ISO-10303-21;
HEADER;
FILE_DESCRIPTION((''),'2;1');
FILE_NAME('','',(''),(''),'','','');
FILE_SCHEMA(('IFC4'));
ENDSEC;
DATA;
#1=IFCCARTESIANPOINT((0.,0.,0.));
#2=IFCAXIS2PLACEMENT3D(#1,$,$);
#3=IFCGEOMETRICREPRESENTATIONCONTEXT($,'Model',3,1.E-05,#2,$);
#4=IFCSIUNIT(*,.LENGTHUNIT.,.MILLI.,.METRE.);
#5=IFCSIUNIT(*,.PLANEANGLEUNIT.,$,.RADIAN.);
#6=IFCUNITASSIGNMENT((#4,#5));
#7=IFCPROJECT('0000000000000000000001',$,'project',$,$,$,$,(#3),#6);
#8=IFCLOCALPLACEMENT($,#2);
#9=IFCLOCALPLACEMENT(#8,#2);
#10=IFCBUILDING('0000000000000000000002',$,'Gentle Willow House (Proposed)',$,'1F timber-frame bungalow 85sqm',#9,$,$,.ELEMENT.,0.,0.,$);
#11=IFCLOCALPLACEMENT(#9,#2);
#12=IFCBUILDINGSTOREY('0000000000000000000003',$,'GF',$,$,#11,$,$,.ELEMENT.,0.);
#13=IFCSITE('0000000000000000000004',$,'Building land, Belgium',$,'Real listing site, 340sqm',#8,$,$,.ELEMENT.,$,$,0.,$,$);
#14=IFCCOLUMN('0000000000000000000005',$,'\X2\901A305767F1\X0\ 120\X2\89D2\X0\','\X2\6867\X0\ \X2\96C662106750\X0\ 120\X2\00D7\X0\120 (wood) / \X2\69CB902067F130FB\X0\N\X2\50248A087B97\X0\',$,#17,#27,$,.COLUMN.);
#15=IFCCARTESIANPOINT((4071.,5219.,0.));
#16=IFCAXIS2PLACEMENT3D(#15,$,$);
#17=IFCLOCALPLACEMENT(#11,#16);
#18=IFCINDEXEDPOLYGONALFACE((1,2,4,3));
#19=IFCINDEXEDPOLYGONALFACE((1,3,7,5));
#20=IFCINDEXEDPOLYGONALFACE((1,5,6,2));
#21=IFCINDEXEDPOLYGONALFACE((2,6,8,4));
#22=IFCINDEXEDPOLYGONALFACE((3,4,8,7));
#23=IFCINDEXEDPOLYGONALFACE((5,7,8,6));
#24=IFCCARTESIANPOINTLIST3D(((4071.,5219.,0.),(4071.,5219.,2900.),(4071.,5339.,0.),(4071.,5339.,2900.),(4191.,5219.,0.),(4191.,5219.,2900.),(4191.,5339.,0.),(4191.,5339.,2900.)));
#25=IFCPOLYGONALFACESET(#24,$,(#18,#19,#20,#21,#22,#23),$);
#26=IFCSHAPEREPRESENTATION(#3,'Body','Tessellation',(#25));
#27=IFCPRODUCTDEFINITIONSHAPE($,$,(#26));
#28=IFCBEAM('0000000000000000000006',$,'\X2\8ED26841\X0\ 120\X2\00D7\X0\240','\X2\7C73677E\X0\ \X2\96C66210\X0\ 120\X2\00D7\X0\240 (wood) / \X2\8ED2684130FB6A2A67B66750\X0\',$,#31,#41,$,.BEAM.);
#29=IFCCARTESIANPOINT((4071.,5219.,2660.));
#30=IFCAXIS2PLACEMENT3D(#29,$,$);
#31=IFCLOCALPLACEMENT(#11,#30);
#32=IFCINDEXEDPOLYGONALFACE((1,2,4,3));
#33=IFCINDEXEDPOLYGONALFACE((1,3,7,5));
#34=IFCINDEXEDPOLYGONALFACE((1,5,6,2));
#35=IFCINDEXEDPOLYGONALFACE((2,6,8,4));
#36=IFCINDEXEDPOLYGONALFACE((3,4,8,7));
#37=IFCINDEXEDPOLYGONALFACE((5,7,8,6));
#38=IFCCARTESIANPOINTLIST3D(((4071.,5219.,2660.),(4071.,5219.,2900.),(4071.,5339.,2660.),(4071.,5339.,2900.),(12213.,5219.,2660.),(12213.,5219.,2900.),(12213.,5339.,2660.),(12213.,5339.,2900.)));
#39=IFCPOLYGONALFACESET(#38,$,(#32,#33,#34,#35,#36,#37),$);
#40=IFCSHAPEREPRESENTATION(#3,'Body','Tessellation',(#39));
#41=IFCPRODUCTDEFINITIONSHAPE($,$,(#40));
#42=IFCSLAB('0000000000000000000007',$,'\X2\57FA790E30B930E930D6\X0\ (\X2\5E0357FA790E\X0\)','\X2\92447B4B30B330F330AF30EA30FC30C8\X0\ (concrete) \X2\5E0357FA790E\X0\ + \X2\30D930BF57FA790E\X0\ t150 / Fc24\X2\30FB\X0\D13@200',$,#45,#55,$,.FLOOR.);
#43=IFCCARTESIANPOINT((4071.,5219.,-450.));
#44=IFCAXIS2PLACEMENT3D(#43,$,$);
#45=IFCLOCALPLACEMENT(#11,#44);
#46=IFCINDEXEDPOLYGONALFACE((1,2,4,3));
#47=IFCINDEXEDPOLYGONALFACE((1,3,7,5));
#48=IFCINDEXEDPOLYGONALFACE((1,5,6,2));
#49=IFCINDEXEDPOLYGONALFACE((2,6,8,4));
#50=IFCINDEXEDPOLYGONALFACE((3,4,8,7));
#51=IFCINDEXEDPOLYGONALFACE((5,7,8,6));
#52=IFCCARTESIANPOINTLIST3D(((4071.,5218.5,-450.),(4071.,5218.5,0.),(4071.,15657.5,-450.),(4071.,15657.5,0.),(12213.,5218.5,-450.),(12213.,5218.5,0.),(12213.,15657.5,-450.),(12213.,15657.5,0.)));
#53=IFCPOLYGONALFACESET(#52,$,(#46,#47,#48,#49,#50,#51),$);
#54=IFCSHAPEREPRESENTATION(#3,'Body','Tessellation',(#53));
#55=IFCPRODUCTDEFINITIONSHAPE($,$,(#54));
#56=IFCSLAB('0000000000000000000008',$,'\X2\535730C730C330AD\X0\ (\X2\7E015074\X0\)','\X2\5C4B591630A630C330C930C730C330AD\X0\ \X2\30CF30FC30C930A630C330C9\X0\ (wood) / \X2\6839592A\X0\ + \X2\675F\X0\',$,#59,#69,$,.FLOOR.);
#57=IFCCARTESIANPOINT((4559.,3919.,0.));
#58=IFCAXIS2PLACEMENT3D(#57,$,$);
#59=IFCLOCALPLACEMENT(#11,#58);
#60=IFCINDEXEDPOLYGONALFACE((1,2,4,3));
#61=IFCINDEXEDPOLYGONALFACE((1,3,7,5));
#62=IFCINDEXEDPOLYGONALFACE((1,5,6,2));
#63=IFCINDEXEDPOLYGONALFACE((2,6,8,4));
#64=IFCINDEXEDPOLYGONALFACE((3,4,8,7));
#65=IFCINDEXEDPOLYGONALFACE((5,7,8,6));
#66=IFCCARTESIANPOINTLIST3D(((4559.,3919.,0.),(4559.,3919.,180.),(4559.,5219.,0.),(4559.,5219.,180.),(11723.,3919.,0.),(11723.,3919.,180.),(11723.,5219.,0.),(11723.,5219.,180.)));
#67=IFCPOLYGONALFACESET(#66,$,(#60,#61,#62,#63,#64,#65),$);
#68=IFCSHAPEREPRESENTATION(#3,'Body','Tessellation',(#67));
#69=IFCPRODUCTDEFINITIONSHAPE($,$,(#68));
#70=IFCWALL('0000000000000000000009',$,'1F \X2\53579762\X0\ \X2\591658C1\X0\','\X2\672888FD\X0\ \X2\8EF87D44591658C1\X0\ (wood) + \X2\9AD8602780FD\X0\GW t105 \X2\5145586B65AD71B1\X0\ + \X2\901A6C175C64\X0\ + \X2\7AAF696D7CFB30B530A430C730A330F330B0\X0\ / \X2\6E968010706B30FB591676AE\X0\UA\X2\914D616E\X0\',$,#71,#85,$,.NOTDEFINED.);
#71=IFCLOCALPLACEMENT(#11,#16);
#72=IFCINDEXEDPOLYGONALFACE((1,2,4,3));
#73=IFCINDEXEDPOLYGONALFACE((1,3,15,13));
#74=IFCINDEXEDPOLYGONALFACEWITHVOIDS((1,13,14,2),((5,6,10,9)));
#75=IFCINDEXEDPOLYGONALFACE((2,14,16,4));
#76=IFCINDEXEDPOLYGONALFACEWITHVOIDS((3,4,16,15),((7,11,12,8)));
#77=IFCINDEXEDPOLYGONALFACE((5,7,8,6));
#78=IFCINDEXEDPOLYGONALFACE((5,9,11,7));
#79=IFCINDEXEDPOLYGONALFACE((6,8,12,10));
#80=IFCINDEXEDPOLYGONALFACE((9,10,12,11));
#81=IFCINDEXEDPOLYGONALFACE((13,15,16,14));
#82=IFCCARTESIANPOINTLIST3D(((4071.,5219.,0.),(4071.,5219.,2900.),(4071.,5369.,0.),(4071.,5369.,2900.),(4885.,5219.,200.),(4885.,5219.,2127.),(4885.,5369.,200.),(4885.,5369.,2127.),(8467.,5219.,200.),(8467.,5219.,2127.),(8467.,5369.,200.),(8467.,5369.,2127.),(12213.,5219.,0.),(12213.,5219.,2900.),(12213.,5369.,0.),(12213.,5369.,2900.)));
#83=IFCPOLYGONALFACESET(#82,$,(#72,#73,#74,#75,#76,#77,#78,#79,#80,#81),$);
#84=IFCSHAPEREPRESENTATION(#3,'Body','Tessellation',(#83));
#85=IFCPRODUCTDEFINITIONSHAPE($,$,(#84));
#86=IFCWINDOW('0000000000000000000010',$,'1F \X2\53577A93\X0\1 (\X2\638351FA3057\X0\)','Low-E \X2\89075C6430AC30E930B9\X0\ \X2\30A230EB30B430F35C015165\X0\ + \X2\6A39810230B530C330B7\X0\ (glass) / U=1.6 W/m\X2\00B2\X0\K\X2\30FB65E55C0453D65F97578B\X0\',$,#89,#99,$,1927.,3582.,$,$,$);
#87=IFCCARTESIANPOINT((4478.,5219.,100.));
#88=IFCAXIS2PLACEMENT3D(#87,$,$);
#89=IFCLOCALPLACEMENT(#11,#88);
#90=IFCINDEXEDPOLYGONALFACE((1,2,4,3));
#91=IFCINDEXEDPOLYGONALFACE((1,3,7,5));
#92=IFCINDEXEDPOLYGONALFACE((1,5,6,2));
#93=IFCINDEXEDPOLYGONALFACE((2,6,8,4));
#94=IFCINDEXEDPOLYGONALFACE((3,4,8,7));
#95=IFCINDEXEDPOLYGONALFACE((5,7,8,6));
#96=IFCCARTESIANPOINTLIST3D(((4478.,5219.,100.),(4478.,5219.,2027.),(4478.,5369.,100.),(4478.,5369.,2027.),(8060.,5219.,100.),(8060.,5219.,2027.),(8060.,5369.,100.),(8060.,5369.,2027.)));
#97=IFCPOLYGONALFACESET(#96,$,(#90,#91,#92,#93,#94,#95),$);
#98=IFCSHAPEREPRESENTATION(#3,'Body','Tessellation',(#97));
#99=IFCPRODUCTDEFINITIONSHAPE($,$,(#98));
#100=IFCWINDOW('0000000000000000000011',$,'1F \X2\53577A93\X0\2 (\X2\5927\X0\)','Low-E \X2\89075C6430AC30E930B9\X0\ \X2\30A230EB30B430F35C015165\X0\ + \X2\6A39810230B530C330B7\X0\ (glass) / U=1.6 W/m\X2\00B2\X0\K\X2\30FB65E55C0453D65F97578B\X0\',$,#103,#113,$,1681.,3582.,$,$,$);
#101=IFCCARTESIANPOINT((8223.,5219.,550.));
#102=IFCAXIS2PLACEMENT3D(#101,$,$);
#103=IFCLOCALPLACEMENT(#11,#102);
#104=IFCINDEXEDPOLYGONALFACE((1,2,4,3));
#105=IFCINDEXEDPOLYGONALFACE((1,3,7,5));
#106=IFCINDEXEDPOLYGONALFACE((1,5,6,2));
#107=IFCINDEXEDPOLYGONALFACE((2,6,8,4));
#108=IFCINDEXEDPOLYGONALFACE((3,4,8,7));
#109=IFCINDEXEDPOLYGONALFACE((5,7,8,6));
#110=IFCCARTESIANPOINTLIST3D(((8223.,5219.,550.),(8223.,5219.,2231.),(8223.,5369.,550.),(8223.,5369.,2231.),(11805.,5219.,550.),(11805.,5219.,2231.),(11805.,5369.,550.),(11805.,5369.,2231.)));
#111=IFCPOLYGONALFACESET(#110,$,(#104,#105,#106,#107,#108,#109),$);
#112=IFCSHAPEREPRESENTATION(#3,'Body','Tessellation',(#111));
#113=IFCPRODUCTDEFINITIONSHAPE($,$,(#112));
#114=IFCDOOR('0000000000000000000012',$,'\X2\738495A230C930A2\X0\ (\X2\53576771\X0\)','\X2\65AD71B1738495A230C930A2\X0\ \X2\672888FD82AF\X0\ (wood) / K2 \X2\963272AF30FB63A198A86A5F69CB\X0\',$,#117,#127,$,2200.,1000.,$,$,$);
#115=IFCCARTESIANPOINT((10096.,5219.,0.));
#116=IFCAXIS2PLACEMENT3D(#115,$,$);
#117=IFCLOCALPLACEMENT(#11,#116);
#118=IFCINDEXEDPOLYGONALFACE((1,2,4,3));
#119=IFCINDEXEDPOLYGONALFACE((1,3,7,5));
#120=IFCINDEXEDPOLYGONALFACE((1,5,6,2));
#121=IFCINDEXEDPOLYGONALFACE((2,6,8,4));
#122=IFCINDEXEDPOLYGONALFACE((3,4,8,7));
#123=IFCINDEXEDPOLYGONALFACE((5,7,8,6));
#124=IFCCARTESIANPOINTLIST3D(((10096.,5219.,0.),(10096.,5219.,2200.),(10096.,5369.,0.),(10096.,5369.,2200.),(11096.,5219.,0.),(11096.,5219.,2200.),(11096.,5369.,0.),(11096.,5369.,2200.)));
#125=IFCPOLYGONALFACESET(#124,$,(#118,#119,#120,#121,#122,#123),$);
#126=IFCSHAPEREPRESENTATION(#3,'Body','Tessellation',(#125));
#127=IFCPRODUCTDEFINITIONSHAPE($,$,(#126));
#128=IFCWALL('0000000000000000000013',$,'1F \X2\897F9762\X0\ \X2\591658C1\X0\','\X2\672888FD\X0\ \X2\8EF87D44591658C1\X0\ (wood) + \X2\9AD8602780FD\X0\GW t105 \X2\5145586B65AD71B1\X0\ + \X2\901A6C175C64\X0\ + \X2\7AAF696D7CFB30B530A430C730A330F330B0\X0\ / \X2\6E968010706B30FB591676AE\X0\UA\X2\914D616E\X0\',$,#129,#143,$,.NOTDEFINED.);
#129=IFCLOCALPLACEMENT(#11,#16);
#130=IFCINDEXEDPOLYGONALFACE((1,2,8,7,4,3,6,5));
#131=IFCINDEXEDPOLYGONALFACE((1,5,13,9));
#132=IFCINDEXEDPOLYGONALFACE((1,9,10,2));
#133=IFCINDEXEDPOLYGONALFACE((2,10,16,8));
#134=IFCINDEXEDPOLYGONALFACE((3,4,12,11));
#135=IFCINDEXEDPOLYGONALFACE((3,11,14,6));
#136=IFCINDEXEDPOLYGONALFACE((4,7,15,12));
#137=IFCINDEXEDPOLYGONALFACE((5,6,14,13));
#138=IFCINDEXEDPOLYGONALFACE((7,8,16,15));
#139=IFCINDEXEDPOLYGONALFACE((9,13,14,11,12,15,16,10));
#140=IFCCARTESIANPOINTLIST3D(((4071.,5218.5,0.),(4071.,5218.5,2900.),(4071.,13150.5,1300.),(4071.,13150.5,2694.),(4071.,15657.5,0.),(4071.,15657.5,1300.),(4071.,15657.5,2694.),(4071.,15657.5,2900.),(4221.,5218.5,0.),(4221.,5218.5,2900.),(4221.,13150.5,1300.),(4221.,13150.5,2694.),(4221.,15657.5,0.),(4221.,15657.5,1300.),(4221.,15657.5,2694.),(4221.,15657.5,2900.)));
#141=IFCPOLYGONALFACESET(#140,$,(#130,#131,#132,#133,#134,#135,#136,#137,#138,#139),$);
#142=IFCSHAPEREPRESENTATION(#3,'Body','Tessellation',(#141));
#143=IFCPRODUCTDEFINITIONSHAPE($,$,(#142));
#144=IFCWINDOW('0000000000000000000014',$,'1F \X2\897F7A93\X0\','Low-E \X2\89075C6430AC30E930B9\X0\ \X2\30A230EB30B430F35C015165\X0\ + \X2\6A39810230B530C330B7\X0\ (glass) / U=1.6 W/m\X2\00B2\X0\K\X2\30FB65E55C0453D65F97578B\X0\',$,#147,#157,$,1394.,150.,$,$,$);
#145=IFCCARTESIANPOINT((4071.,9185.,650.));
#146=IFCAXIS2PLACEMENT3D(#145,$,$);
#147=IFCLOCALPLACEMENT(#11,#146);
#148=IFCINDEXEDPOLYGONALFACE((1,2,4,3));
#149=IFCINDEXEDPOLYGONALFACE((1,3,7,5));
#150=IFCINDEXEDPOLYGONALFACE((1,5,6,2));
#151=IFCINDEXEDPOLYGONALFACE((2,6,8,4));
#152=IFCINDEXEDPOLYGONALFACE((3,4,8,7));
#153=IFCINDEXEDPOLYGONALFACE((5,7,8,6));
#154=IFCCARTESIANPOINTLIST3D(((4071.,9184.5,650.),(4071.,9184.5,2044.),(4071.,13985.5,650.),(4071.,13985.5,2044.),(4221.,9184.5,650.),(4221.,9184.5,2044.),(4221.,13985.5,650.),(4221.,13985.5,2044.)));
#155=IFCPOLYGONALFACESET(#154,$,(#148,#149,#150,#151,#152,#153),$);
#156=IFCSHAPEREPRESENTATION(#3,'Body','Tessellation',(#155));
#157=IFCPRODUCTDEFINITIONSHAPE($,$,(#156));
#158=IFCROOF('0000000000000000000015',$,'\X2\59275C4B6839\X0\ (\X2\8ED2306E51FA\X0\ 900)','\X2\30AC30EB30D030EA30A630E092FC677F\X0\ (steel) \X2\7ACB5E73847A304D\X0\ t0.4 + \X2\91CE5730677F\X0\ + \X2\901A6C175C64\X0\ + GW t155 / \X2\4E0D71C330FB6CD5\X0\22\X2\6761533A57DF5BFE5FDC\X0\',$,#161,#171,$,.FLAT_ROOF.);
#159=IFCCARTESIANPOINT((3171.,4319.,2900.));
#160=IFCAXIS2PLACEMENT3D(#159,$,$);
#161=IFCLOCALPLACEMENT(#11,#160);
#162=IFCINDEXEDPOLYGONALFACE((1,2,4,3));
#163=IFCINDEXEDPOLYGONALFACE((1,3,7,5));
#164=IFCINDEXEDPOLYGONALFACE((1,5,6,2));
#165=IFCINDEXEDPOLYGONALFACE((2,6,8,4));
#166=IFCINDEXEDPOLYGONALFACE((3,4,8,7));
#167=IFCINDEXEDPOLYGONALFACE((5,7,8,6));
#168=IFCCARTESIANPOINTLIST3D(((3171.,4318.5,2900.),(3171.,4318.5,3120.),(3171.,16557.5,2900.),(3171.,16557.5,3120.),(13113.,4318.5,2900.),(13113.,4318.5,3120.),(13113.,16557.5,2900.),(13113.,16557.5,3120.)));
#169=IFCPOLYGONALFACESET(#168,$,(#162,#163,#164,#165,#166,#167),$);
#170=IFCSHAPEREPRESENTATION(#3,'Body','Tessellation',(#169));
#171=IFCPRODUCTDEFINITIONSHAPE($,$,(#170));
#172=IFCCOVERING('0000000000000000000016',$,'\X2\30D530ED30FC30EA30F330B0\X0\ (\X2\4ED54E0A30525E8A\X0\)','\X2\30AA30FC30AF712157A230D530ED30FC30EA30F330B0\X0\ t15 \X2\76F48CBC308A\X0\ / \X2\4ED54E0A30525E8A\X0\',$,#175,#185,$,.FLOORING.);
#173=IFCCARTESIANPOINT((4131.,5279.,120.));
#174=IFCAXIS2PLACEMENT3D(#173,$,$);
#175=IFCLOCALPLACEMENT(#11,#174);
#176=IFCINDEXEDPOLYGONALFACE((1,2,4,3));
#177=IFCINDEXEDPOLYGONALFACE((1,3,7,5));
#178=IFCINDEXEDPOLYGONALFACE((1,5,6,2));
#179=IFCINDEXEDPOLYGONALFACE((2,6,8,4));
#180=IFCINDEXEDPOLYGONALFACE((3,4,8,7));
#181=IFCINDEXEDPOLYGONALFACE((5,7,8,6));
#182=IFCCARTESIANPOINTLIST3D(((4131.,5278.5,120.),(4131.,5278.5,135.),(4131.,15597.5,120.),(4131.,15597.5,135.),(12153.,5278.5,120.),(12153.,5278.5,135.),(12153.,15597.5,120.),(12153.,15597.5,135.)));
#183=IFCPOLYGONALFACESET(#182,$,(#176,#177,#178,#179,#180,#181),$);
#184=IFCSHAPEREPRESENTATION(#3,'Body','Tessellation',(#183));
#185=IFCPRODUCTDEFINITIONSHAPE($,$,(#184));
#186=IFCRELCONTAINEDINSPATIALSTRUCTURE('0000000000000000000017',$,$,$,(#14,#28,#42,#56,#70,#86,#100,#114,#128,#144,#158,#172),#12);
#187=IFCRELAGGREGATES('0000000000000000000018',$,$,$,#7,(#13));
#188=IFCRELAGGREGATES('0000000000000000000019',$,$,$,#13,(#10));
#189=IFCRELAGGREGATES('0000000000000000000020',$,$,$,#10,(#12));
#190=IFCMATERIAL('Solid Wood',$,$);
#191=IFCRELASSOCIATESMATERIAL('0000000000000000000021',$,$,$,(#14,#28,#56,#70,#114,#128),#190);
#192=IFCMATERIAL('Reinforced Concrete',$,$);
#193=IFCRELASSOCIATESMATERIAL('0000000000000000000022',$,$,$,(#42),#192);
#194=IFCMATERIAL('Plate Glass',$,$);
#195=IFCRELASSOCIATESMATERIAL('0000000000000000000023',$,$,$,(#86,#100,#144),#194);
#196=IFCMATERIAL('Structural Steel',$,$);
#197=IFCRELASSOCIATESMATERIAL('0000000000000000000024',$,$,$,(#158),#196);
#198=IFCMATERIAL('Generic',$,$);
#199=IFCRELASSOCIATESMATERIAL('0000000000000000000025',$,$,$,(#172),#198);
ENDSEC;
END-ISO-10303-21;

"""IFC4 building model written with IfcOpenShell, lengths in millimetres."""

from ifc_helpers import new_model, si_unit, frame, frame_2d, origin, place, context, project, spatial, rectangle, extrude, material, element, fill, save


model = new_model("IFC4")

# Units and contexts
model_context = context("Model", 3, precision=1e-05, world=origin())
ifc_project = project(units=[si_unit("LENGTHUNIT", "METRE", prefix="MILLI"), si_unit("PLANEANGLEUNIT", "RADIAN")], contexts=[model_context])

# Site, building, storey
site_placement = place(None, origin())
site = spatial("IfcSite", under=ifc_project, at=site_placement, Name="Building land, Belgium", ObjectType="Real listing site, 340sqm", CompositionType="ELEMENT", RefElevation=0.0)
building_placement = place(site_placement, origin())
building = spatial("IfcBuilding", under=site, at=building_placement, Name="Gentle Willow House (Proposed)", ObjectType="1F timber-frame bungalow 85sqm", CompositionType="ELEMENT", ElevationOfRefHeight=0.0, ElevationOfTerrain=0.0)
storey_placement = place(building_placement, origin())
storey = spatial("IfcBuildingStorey", under=building, at=storey_placement, Name="GF", CompositionType="ELEMENT", Elevation=0.0)

# Column
ifc_material_1 = material(Name="Solid Wood")
column_1_placement = place(storey_placement, frame((4071.0, 5219.0, 0.0)))
element("IfcColumn", 1, at=column_1_placement, inside=storey, material=ifc_material_1, Name="通し柱 120角", Description="桧 集成材 120×120 (wood) / 構造柱・N値計算", PredefinedType="COLUMN", context=model_context, shape_type="SweptSolid", body=[
    extrude(rectangle(XDim=120.0, YDim=120.0, at=frame_2d((60.0, 60.0))), frame((4071.0, 5219.0, 0.0)), (0.0, 0.0, 1.0), 2900.0),
])

# Beam
beam_1_placement = place(storey_placement, frame((4071.0, 5219.0, 2660.0)))
element("IfcBeam", 2, at=beam_1_placement, inside=storey, material=ifc_material_1, Name="軒桁 120×240", Description="米松 集成 120×240 (wood) / 軒桁・横架材", PredefinedType="BEAM", context=model_context, shape_type="SweptSolid", body=[
    extrude(rectangle(XDim=8142.0, YDim=120.0, at=frame_2d((4071.0, 60.0))), frame((4071.0, 5219.0, 2660.0)), (0.0, 0.0, 1.0), 240.0),
])

# Slabs
ifc_material_2 = material(Name="Reinforced Concrete")
slab_1_placement = place(storey_placement, frame((4071.0, 5219.0, -450.0)))
element("IfcSlab", 3, at=slab_1_placement, inside=storey, material=ifc_material_2, Name="基礎スラブ (布基礎)", Description="鉄筋コンクリート (concrete) 布基礎 + ベタ基礎 t150 / Fc24・D13@200", PredefinedType="FLOOR", context=model_context, shape_type="SweptSolid", body=[
    extrude(rectangle(XDim=8142.0, YDim=10439.0, at=frame_2d((4071.0, 5219.0))), frame((4071.0, 5219.0, -450.0)), (0.0, 0.0, 1.0), 450.0),
])
slab_2_placement = place(storey_placement, frame((4559.0, 3919.0, 0.0)))
element("IfcSlab", 4, at=slab_2_placement, inside=storey, material=ifc_material_1, Name="南デッキ (縁側)", Description="屋外ウッドデッキ ハードウッド (wood) / 根太 + 束", PredefinedType="FLOOR", context=model_context, shape_type="SweptSolid", body=[
    extrude(rectangle(XDim=7164.0, YDim=1300.0, at=frame_2d((3582.0, 650.0))), frame((4559.0, 3919.0, 0.0)), (0.0, 0.0, 1.0), 180.0),
])

# Wall, openings, windows, door
wall_1_placement = place(storey_placement, frame((4071.0, 5219.0, 0.0)))
wall_1 = element("IfcWall", 5, at=wall_1_placement, inside=storey, material=ifc_material_1, Name="1F 南面 外壁", Description="木製 軸組外壁 (wood) + 高性能GW t105 充填断熱 + 通気層 + 窯業系サイディング / 準耐火・外皮UA配慮", PredefinedType="NOTDEFINED", context=model_context, shape_type="SweptSolid", body=[
    extrude(rectangle(XDim=8142.0, YDim=150.0, at=frame_2d((4071.0, 75.0))), frame((4071.0, 5219.0, 0.0)), (0.0, 0.0, 1.0), 2900.0),
])
opening_1_placement = place(storey_placement, frame((4478.0, 5219.0, 100.0)))
opening_1 = element("IfcOpeningElement", 6, at=opening_1_placement, cuts=wall_1, PredefinedType="NOTDEFINED", context=model_context, shape_type="SweptSolid", body=[
    extrude(rectangle(XDim=3582.0, YDim=150.0, at=frame_2d((1791.0, 75.0))), frame((4478.0, 5219.0, 100.0)), (0.0, 0.0, 1.0), 1927.0),
])
opening_2_placement = place(storey_placement, frame((8223.0, 5219.0, 550.0)))
opening_2 = element("IfcOpeningElement", 7, at=opening_2_placement, cuts=wall_1, PredefinedType="NOTDEFINED", context=model_context, shape_type="SweptSolid", body=[
    extrude(rectangle(XDim=3582.0, YDim=150.0, at=frame_2d((1791.0, 75.0))), frame((8223.0, 5219.0, 550.0)), (0.0, 0.0, 1.0), 1681.0),
])
opening_3_placement = place(storey_placement, frame((10096.0, 5219.0, 0.0)))
opening_3 = element("IfcOpeningElement", 8, at=opening_3_placement, cuts=wall_1, PredefinedType="NOTDEFINED", context=model_context, shape_type="SweptSolid", body=[
    extrude(rectangle(XDim=1000.0, YDim=150.0, at=frame_2d((500.0, 75.0))), frame((10096.0, 5219.0, 0.0)), (0.0, 0.0, 1.0), 2200.0),
])
ifc_material_3 = material(Name="Plate Glass")
window_1_placement = place(storey_placement, frame((4478.0, 5219.0, 100.0)))
window_1 = element("IfcWindow", 9, at=window_1_placement, inside=storey, material=ifc_material_3, Name="1F 南窓1 (掃出し)", Description="Low-E 複層ガラス アルゴン封入 + 樹脂サッシ (glass) / U=1.6 W/m²K・日射取得型", OverallHeight=1927.0, OverallWidth=3582.0, context=model_context, shape_type="SweptSolid", body=[
    extrude(rectangle(XDim=3582.0, YDim=150.0, at=frame_2d((1791.0, 75.0))), frame((4478.0, 5219.0, 100.0)), (0.0, 0.0, 1.0), 1927.0),
])
fill(opening_1, window_1)
window_2_placement = place(storey_placement, frame((8223.0, 5219.0, 550.0)))
window_2 = element("IfcWindow", 10, at=window_2_placement, inside=storey, material=ifc_material_3, Name="1F 南窓2 (大)", Description="Low-E 複層ガラス アルゴン封入 + 樹脂サッシ (glass) / U=1.6 W/m²K・日射取得型", OverallHeight=1681.0, OverallWidth=3582.0, context=model_context, shape_type="SweptSolid", body=[
    extrude(rectangle(XDim=3582.0, YDim=150.0, at=frame_2d((1791.0, 75.0))), frame((8223.0, 5219.0, 550.0)), (0.0, 0.0, 1.0), 1681.0),
])
fill(opening_2, window_2)
door_placement = place(storey_placement, frame((10096.0, 5219.0, 0.0)))
door = element("IfcDoor", 11, at=door_placement, inside=storey, material=ifc_material_1, Name="玄関ドア (南東)", Description="断熱玄関ドア 木製芯 (wood) / K2 防犯・採風機構", OverallHeight=2200.0, OverallWidth=1000.0, context=model_context, shape_type="SweptSolid", body=[
    extrude(rectangle(XDim=1000.0, YDim=150.0, at=frame_2d((500.0, 75.0))), frame((10096.0, 5219.0, 0.0)), (0.0, 0.0, 1.0), 2200.0),
])
fill(opening_3, door)

# Wall, opening, window
wall_2_placement = place(storey_placement, frame((4071.0, 5219.0, 0.0)))
wall_2 = element("IfcWall", 12, at=wall_2_placement, inside=storey, material=ifc_material_1, Name="1F 西面 外壁", Description="木製 軸組外壁 (wood) + 高性能GW t105 充填断熱 + 通気層 + 窯業系サイディング / 準耐火・外皮UA配慮", PredefinedType="NOTDEFINED", context=model_context, shape_type="SweptSolid", body=[
    extrude(rectangle(XDim=150.0, YDim=10439.0, at=frame_2d((75.0, 5219.0))), frame((4071.0, 5219.0, 0.0)), (0.0, 0.0, 1.0), 2900.0),
])
opening_4_placement = place(storey_placement, frame((4071.0, 9185.0, 650.0)))
opening_4 = element("IfcOpeningElement", 13, at=opening_4_placement, cuts=wall_2, PredefinedType="NOTDEFINED", context=model_context, shape_type="SweptSolid", body=[
    extrude(rectangle(XDim=150.0, YDim=4801.0, at=frame_2d((75.0, 2400.0))), frame((4071.0, 9185.0, 650.0)), (0.0, 0.0, 1.0), 1394.0),
])
window_3_placement = place(storey_placement, frame((4071.0, 9185.0, 650.0)))
window_3 = element("IfcWindow", 14, at=window_3_placement, inside=storey, material=ifc_material_3, Name="1F 西窓", Description="Low-E 複層ガラス アルゴン封入 + 樹脂サッシ (glass) / U=1.6 W/m²K・日射取得型", OverallHeight=1394.0, OverallWidth=150.0, context=model_context, shape_type="SweptSolid", body=[
    extrude(rectangle(XDim=150.0, YDim=4801.0, at=frame_2d((75.0, 2400.0))), frame((4071.0, 9185.0, 650.0)), (0.0, 0.0, 1.0), 1394.0),
])
fill(opening_4, window_3)

# Roof
ifc_material_4 = material(Name="Structural Steel")
roof_placement = place(storey_placement, frame((3171.0, 4319.0, 2900.0)))
element("IfcRoof", 15, at=roof_placement, inside=storey, material=ifc_material_4, Name="大屋根 (軒の出 900)", Description="ガルバリウム鋼板 (steel) 立平葺き t0.4 + 野地板 + 通気層 + GW t155 / 不燃・法22条区域対応", PredefinedType="FLAT_ROOF", context=model_context, shape_type="SweptSolid", body=[
    extrude(rectangle(XDim=9942.0, YDim=12239.0, at=frame_2d((4971.0, 6119.0))), frame((3171.0, 4319.0, 2900.0)), (0.0, 0.0, 1.0), 220.0),
])

# Covering
ifc_material_5 = material(Name="Generic")
covering_1_placement = place(storey_placement, frame((4131.0, 5279.0, 120.0)))
element("IfcCovering", 16, at=covering_1_placement, inside=storey, material=ifc_material_5, Name="フローリング (仕上げ床)", Description="オーク無垢フローリング t15 直貼り / 仕上げ床", PredefinedType="FLOORING", context=model_context, shape_type="SweptSolid", body=[
    extrude(rectangle(XDim=8022.0, YDim=10319.0, at=frame_2d((4011.0, 5159.0))), frame((4131.0, 5279.0, 120.0)), (0.0, 0.0, 1.0), 15.0),
])

save(model, "model.ifc")
